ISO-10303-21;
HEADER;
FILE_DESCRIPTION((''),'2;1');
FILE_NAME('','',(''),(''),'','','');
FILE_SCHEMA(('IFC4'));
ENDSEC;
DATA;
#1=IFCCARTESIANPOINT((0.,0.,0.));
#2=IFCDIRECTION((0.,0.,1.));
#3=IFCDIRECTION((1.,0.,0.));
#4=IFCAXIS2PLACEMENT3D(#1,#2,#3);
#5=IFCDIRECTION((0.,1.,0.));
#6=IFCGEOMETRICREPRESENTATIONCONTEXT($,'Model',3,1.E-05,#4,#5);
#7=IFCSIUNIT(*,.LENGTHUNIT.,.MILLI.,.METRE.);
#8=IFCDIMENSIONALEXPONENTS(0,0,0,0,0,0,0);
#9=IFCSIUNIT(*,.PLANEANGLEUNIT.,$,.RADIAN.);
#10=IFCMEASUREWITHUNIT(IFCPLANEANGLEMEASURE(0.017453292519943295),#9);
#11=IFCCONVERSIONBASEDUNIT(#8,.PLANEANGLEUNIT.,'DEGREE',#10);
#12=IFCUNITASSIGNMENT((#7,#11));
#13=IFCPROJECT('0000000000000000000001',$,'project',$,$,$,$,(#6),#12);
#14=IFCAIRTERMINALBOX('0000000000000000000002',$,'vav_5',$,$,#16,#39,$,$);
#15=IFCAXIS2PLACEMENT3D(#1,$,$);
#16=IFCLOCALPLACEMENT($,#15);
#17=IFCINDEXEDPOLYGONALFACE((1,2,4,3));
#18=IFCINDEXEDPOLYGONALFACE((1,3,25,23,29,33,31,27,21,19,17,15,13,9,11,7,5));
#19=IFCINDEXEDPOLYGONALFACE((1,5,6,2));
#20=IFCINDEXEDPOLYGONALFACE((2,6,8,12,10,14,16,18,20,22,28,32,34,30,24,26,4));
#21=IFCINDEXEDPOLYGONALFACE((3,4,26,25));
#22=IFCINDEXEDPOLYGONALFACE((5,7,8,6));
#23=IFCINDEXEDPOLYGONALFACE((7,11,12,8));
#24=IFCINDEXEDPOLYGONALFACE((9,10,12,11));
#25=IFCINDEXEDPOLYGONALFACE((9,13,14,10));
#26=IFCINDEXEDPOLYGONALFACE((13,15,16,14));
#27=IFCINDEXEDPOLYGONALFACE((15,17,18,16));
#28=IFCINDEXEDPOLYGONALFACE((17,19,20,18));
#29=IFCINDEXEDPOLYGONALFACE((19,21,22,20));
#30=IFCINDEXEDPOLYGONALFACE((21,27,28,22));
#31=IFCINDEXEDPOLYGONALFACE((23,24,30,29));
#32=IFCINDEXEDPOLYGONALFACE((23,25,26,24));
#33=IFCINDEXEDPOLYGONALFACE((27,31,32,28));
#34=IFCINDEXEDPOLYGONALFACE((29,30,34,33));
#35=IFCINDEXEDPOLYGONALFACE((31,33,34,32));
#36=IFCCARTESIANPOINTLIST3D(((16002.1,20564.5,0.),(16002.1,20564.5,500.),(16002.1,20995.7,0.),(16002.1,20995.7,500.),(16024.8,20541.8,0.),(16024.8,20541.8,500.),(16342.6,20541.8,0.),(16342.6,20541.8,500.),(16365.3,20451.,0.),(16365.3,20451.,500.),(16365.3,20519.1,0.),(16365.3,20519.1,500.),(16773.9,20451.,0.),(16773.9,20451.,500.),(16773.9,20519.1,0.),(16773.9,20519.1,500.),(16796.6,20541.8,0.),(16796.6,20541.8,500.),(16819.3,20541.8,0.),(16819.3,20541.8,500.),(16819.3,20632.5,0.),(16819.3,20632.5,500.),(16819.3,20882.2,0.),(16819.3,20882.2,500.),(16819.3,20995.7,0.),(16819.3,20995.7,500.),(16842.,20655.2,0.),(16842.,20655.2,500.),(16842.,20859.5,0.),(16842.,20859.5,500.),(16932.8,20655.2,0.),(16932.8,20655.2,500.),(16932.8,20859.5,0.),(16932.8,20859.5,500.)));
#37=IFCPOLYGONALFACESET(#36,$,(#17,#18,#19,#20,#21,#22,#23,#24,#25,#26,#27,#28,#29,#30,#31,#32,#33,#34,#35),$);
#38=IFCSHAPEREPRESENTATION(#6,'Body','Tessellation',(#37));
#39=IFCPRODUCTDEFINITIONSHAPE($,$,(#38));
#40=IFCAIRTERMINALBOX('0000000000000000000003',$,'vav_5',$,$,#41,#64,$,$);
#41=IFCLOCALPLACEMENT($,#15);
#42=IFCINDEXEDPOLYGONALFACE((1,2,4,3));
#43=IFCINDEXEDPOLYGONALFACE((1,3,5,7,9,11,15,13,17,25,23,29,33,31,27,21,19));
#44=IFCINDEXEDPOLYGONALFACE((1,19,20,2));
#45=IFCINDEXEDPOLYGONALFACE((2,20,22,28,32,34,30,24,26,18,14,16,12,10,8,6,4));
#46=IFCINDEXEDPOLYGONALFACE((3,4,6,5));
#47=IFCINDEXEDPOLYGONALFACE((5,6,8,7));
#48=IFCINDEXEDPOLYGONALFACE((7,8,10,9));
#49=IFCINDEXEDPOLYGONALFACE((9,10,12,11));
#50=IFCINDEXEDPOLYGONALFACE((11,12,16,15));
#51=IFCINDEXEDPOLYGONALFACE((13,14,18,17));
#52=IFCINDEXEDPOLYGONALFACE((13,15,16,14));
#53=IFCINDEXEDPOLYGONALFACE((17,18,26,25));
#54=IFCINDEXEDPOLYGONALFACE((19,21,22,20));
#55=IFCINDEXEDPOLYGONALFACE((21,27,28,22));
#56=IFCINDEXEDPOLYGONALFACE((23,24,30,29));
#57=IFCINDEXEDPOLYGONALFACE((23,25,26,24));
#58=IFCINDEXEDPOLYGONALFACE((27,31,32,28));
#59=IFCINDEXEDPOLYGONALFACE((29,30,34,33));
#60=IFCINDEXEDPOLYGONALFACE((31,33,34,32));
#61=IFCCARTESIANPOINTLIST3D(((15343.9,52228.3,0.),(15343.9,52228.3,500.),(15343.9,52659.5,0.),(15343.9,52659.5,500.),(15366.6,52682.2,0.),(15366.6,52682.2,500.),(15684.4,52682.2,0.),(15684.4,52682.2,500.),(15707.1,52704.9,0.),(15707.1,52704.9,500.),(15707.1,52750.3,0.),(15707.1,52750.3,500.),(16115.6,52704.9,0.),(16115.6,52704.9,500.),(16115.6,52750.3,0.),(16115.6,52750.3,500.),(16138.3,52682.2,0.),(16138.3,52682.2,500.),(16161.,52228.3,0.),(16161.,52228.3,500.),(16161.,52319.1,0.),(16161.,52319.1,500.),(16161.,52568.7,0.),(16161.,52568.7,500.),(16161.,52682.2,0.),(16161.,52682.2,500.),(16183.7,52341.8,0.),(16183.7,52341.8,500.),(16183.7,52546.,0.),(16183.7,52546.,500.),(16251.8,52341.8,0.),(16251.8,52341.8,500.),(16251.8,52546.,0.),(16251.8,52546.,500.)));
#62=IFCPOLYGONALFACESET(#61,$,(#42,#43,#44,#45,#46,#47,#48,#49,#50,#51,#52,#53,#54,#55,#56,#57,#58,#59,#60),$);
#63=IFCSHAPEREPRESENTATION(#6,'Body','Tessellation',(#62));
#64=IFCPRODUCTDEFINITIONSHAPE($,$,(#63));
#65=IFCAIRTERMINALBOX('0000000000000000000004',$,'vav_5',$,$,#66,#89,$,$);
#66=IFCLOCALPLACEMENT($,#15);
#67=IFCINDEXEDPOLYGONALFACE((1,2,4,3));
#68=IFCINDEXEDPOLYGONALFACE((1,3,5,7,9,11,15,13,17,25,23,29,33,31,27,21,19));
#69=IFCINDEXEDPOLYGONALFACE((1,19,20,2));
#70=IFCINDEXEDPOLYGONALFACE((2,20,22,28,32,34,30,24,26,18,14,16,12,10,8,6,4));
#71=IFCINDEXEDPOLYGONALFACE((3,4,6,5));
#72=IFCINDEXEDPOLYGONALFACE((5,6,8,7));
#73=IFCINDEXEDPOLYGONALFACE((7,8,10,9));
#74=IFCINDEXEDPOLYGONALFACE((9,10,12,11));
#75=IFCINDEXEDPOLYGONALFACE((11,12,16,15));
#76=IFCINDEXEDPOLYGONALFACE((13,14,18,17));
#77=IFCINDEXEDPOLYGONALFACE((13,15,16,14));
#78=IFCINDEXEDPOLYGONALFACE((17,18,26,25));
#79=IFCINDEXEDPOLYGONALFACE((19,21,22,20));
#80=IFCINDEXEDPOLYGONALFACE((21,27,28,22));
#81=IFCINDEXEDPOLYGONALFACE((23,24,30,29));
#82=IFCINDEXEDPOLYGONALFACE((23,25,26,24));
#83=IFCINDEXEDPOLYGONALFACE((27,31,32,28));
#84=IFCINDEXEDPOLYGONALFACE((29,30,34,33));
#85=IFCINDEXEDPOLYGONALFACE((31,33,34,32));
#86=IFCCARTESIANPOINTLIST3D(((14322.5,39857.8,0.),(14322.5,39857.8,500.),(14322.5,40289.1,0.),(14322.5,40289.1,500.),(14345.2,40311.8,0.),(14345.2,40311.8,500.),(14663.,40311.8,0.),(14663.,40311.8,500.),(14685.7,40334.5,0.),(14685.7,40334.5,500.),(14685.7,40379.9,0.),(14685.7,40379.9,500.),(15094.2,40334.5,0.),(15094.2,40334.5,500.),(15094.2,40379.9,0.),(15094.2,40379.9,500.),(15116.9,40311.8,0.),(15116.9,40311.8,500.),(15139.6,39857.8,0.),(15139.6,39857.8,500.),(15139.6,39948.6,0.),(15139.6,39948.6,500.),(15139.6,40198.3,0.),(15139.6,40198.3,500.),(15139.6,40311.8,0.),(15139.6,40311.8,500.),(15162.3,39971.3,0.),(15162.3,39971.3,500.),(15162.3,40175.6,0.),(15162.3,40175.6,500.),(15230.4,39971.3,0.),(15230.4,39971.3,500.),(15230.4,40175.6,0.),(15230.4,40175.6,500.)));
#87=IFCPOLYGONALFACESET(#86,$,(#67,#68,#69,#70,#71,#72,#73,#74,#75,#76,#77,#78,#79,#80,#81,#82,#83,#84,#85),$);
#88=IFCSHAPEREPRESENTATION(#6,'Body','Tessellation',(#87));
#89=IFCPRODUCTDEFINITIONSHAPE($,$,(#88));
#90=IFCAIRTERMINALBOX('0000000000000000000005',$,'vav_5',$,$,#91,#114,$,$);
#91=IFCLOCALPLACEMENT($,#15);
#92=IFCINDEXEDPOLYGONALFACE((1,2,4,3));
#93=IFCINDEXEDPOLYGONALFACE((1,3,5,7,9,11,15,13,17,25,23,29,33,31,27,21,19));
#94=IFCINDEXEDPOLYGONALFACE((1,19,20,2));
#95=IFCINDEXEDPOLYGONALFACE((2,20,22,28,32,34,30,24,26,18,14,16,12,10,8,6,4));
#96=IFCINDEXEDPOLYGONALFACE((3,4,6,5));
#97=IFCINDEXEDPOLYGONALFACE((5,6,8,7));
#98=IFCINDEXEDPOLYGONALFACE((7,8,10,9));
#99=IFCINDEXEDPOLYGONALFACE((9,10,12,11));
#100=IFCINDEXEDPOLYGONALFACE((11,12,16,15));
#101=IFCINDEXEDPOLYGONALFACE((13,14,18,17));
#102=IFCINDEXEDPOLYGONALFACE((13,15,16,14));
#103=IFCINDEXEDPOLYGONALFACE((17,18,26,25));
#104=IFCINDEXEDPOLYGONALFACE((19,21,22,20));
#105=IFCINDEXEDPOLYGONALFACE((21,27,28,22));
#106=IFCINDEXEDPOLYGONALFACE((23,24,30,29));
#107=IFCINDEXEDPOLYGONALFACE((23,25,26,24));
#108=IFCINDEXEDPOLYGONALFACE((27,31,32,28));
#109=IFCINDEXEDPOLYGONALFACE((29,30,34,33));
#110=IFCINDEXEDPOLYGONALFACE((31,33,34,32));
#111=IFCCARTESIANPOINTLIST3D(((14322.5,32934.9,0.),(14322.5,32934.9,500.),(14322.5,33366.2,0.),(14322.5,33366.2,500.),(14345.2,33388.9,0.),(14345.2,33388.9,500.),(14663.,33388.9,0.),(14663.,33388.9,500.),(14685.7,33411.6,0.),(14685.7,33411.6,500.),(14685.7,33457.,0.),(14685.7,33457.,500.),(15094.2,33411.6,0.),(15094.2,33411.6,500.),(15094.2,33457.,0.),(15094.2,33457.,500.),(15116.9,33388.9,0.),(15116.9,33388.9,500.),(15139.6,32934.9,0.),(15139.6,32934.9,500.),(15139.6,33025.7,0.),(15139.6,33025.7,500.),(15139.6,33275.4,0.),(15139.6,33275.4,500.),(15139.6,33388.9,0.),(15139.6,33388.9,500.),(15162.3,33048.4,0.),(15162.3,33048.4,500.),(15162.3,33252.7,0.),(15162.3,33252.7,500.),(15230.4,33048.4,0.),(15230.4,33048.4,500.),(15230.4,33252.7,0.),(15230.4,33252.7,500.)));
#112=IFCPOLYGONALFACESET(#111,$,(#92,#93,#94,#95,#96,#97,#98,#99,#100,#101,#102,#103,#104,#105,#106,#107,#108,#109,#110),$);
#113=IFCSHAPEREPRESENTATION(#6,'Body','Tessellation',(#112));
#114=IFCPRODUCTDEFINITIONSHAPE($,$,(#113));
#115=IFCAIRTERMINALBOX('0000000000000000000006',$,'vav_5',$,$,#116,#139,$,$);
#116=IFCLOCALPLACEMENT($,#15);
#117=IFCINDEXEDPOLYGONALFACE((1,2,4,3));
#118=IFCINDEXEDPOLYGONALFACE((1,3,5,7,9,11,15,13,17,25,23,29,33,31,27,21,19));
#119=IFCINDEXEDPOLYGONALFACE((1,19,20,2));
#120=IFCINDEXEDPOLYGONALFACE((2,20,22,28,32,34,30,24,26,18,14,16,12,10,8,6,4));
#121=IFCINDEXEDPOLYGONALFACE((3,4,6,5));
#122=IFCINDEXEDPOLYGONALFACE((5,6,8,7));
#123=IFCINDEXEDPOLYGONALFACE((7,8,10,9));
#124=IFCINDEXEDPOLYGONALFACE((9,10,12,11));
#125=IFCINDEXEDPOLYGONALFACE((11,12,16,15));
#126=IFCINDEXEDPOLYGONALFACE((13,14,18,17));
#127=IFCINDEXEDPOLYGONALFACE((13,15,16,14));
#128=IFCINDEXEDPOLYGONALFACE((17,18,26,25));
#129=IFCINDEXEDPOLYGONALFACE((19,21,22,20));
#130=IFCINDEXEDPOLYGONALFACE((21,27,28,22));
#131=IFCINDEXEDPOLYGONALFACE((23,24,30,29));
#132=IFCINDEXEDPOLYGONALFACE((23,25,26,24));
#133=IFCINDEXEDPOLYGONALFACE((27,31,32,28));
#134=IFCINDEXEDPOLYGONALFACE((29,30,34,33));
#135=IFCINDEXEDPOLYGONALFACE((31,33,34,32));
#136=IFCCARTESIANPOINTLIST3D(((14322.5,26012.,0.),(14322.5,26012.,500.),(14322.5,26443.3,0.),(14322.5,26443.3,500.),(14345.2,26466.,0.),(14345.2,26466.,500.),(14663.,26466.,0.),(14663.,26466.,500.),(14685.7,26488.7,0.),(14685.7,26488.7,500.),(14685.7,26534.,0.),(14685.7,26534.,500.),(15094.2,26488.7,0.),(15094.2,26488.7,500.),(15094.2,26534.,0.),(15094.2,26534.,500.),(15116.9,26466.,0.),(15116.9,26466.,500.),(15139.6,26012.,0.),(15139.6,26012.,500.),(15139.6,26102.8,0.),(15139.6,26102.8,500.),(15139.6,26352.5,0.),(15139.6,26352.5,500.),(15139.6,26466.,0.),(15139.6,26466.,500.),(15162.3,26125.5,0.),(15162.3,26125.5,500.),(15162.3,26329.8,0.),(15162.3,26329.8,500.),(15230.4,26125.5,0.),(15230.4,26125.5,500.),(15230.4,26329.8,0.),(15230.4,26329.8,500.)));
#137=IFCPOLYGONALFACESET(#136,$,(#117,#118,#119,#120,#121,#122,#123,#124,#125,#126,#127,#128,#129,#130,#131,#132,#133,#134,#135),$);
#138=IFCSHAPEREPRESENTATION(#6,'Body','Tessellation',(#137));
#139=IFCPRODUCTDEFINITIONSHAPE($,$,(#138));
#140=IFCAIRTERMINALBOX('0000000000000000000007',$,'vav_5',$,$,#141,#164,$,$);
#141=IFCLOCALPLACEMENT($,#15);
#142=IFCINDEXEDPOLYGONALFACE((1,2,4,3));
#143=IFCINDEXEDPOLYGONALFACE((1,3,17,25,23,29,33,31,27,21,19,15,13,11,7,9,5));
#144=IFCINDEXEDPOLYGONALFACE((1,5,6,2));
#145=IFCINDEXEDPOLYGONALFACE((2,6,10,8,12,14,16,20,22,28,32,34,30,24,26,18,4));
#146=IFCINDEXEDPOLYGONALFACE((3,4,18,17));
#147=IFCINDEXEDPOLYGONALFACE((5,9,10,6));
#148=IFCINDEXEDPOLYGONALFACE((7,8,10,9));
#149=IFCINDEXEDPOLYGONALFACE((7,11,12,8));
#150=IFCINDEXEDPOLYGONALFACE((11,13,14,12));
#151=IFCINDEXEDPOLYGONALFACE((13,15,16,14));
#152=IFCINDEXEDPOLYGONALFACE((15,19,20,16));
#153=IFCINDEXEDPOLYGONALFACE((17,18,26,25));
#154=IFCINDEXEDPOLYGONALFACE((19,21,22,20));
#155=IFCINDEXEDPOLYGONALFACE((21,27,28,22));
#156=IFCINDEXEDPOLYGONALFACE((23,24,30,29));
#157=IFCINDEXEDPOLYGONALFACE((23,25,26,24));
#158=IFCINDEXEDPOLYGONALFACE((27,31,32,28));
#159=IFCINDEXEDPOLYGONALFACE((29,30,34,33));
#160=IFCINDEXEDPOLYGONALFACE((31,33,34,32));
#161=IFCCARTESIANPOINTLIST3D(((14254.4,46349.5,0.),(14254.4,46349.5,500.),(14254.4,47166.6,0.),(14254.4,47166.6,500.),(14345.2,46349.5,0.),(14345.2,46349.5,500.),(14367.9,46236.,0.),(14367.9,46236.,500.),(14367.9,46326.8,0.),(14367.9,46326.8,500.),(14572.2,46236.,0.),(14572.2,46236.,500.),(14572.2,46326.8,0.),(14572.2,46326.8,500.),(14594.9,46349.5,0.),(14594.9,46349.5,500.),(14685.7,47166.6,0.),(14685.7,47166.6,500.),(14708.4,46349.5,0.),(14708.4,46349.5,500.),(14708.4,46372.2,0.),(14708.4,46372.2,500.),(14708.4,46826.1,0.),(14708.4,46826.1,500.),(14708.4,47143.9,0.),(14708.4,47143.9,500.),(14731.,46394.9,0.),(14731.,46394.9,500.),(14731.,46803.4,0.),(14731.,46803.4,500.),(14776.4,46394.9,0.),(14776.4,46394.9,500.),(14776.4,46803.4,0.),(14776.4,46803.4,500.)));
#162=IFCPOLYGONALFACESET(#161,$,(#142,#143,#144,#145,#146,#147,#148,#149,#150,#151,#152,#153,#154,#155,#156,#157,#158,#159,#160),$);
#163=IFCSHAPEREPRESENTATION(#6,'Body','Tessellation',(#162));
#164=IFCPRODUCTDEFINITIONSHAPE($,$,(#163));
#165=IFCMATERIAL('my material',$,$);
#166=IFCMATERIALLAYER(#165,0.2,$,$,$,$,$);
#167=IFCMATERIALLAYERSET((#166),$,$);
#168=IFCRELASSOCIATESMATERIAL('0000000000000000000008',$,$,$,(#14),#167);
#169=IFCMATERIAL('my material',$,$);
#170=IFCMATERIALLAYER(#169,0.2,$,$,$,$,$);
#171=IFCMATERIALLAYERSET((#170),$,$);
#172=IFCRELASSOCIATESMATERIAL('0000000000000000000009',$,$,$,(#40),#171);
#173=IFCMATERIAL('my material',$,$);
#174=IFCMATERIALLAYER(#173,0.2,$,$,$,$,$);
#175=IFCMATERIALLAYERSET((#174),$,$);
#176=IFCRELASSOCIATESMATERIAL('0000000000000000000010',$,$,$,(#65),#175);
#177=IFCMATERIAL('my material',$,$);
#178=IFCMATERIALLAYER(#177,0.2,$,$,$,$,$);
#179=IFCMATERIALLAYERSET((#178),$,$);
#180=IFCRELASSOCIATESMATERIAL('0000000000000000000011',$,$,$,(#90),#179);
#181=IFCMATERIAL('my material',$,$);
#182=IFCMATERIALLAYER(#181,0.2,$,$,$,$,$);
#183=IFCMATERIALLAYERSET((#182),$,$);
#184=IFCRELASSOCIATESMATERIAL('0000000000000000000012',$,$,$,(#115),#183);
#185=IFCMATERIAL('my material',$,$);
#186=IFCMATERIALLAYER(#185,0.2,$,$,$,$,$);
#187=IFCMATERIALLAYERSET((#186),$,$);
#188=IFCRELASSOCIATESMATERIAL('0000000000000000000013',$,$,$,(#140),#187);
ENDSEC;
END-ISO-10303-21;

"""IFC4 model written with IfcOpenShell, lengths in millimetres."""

from ifc_helpers import new_model, entity, si_unit, converted_unit, direction, origin_with_axes, place, context, project, polyline, outline, extrude, material, layer, layer_set, layer_usage, element, save


model = new_model("IFC4")

# Units and contexts
model_context = context("Model", 3, precision=1e-05, world=origin_with_axes(), true_north=direction((0.0, 1.0, 0.0)))
ifc_project = project(units=[si_unit("LENGTHUNIT", "METRE", prefix="MILLI"), converted_unit("PLANEANGLEUNIT", "DEGREE", entity("IfcPlaneAngleMeasure", 0.017453292519943295), si_unit("PLANEANGLEUNIT", "RADIAN"), dimensions=[0, 0, 0, 0, 0, 0, 0])], contexts=[model_context])

# Air terminal boxes
ifc_material_1 = material(Name="my material")
ifc_layer_1 = layer(ifc_material_1, 0.2)
ifc_layer_set_1 = layer_set([ifc_layer_1])
ifc_layer_usage_1 = layer_usage(ifc_layer_set_1, "AXIS2", "POSITIVE", -0.1)
air_terminal_box_1_placement = place(None, origin_with_axes())
element("IfcAirTerminalBox", 1, at=air_terminal_box_1_placement, material=ifc_layer_usage_1, Name="vav_5", context=model_context, shape_type="SweptSolid", body=[
    extrude(outline(polyline([(16002.1, 20564.5), (16024.8, 20541.8), (16342.6, 20541.8), (16365.3, 20519.1), (16365.3, 20451.0), (16773.9, 20451.0), (16773.9, 20519.1), (16796.6, 20541.8), (16819.3, 20541.8), (16819.3, 20632.5), (16842.0, 20655.2), (16932.8, 20655.2), (16932.8, 20859.5), (16842.0, 20859.5), (16819.3, 20882.2), (16819.3, 20995.7), (16002.1, 20995.7), (16002.1, 20564.5)])), origin_with_axes(), (0.0, 0.0, 1.0), 500.0),
])
ifc_material_2 = material(Name="my material")
ifc_layer_2 = layer(ifc_material_2, 0.2)
ifc_layer_set_2 = layer_set([ifc_layer_2])
ifc_layer_usage_2 = layer_usage(ifc_layer_set_2, "AXIS2", "POSITIVE", -0.1)
air_terminal_box_2_placement = place(None, origin_with_axes())
element("IfcAirTerminalBox", 2, at=air_terminal_box_2_placement, material=ifc_layer_usage_2, Name="vav_5", context=model_context, shape_type="SweptSolid", body=[
    extrude(outline(polyline([(15343.9, 52228.3), (16161.0, 52228.3), (16161.0, 52319.1), (16183.7, 52341.8), (16251.8, 52341.8), (16251.8, 52546.0), (16183.7, 52546.0), (16161.0, 52568.7), (16161.0, 52682.2), (16138.3, 52682.2), (16115.6, 52704.9), (16115.6, 52750.3), (15707.1, 52750.3), (15707.1, 52704.9), (15684.4, 52682.2), (15366.6, 52682.2), (15343.9, 52659.5), (15343.9, 52228.3)])), origin_with_axes(), (0.0, 0.0, 1.0), 500.0),
])
ifc_material_3 = material(Name="my material")
ifc_layer_3 = layer(ifc_material_3, 0.2)
ifc_layer_set_3 = layer_set([ifc_layer_3])
ifc_layer_usage_3 = layer_usage(ifc_layer_set_3, "AXIS2", "POSITIVE", -0.1)
air_terminal_box_3_placement = place(None, origin_with_axes())
element("IfcAirTerminalBox", 3, at=air_terminal_box_3_placement, material=ifc_layer_usage_3, Name="vav_5", context=model_context, shape_type="SweptSolid", body=[
    extrude(outline(polyline([(14322.5, 39857.8), (15139.6, 39857.8), (15139.6, 39948.6), (15162.3, 39971.3), (15230.4, 39971.3), (15230.4, 40175.6), (15162.3, 40175.6), (15139.6, 40198.3), (15139.6, 40311.8), (15116.9, 40311.8), (15094.2, 40334.5), (15094.2, 40379.9), (14685.7, 40379.9), (14685.7, 40334.5), (14663.0, 40311.8), (14345.2, 40311.8), (14322.5, 40289.1), (14322.5, 39857.8)])), origin_with_axes(), (0.0, 0.0, 1.0), 500.0),
])
ifc_material_4 = material(Name="my material")
ifc_layer_4 = layer(ifc_material_4, 0.2)
ifc_layer_set_4 = layer_set([ifc_layer_4])
ifc_layer_usage_4 = layer_usage(ifc_layer_set_4, "AXIS2", "POSITIVE", -0.1)
air_terminal_box_4_placement = place(None, origin_with_axes())
element("IfcAirTerminalBox", 4, at=air_terminal_box_4_placement, material=ifc_layer_usage_4, Name="vav_5", context=model_context, shape_type="SweptSolid", body=[
    extrude(outline(polyline([(14322.5, 32934.9), (15139.6, 32934.9), (15139.6, 33025.7), (15162.3, 33048.4), (15230.4, 33048.4), (15230.4, 33252.7), (15162.3, 33252.7), (15139.6, 33275.4), (15139.6, 33388.9), (15116.9, 33388.9), (15094.2, 33411.6), (15094.2, 33457.0), (14685.7, 33457.0), (14685.7, 33411.6), (14663.0, 33388.9), (14345.2, 33388.9), (14322.5, 33366.2), (14322.5, 32934.9)])), origin_with_axes(), (0.0, 0.0, 1.0), 500.0),
])
ifc_material_5 = material(Name="my material")
ifc_layer_5 = layer(ifc_material_5, 0.2)
ifc_layer_set_5 = layer_set([ifc_layer_5])
ifc_layer_usage_5 = layer_usage(ifc_layer_set_5, "AXIS2", "POSITIVE", -0.1)
air_terminal_box_5_placement = place(None, origin_with_axes())
element("IfcAirTerminalBox", 5, at=air_terminal_box_5_placement, material=ifc_layer_usage_5, Name="vav_5", context=model_context, shape_type="SweptSolid", body=[
    extrude(outline(polyline([(14322.5, 26012.0), (15139.6, 26012.0), (15139.6, 26102.8), (15162.3, 26125.5), (15230.4, 26125.5), (15230.4, 26329.8), (15162.3, 26329.8), (15139.6, 26352.5), (15139.6, 26466.0), (15116.9, 26466.0), (15094.2, 26488.7), (15094.2, 26534.0), (14685.7, 26534.0), (14685.7, 26488.7), (14663.0, 26466.0), (14345.2, 26466.0), (14322.5, 26443.3), (14322.5, 26012.0)])), origin_with_axes(), (0.0, 0.0, 1.0), 500.0),
])
ifc_material_6 = material(Name="my material")
ifc_layer_6 = layer(ifc_material_6, 0.2)
ifc_layer_set_6 = layer_set([ifc_layer_6])
ifc_layer_usage_6 = layer_usage(ifc_layer_set_6, "AXIS2", "POSITIVE", -0.1)
air_terminal_box_6_placement = place(None, origin_with_axes())
element("IfcAirTerminalBox", 6, at=air_terminal_box_6_placement, material=ifc_layer_usage_6, Name="vav_5", context=model_context, shape_type="SweptSolid", body=[
    extrude(outline(polyline([(14254.4, 46349.5), (14345.2, 46349.5), (14367.9, 46326.8), (14367.9, 46236.0), (14572.2, 46236.0), (14572.2, 46326.8), (14594.9, 46349.5), (14708.4, 46349.5), (14708.4, 46372.2), (14731.0, 46394.9), (14776.4, 46394.9), (14776.4, 46803.4), (14731.0, 46803.4), (14708.4, 46826.1), (14708.4, 47143.9), (14685.7, 47166.6), (14254.4, 47166.6), (14254.4, 46349.5)])), origin_with_axes(), (0.0, 0.0, 1.0), 500.0),
])

save(model, "model.ifc")
